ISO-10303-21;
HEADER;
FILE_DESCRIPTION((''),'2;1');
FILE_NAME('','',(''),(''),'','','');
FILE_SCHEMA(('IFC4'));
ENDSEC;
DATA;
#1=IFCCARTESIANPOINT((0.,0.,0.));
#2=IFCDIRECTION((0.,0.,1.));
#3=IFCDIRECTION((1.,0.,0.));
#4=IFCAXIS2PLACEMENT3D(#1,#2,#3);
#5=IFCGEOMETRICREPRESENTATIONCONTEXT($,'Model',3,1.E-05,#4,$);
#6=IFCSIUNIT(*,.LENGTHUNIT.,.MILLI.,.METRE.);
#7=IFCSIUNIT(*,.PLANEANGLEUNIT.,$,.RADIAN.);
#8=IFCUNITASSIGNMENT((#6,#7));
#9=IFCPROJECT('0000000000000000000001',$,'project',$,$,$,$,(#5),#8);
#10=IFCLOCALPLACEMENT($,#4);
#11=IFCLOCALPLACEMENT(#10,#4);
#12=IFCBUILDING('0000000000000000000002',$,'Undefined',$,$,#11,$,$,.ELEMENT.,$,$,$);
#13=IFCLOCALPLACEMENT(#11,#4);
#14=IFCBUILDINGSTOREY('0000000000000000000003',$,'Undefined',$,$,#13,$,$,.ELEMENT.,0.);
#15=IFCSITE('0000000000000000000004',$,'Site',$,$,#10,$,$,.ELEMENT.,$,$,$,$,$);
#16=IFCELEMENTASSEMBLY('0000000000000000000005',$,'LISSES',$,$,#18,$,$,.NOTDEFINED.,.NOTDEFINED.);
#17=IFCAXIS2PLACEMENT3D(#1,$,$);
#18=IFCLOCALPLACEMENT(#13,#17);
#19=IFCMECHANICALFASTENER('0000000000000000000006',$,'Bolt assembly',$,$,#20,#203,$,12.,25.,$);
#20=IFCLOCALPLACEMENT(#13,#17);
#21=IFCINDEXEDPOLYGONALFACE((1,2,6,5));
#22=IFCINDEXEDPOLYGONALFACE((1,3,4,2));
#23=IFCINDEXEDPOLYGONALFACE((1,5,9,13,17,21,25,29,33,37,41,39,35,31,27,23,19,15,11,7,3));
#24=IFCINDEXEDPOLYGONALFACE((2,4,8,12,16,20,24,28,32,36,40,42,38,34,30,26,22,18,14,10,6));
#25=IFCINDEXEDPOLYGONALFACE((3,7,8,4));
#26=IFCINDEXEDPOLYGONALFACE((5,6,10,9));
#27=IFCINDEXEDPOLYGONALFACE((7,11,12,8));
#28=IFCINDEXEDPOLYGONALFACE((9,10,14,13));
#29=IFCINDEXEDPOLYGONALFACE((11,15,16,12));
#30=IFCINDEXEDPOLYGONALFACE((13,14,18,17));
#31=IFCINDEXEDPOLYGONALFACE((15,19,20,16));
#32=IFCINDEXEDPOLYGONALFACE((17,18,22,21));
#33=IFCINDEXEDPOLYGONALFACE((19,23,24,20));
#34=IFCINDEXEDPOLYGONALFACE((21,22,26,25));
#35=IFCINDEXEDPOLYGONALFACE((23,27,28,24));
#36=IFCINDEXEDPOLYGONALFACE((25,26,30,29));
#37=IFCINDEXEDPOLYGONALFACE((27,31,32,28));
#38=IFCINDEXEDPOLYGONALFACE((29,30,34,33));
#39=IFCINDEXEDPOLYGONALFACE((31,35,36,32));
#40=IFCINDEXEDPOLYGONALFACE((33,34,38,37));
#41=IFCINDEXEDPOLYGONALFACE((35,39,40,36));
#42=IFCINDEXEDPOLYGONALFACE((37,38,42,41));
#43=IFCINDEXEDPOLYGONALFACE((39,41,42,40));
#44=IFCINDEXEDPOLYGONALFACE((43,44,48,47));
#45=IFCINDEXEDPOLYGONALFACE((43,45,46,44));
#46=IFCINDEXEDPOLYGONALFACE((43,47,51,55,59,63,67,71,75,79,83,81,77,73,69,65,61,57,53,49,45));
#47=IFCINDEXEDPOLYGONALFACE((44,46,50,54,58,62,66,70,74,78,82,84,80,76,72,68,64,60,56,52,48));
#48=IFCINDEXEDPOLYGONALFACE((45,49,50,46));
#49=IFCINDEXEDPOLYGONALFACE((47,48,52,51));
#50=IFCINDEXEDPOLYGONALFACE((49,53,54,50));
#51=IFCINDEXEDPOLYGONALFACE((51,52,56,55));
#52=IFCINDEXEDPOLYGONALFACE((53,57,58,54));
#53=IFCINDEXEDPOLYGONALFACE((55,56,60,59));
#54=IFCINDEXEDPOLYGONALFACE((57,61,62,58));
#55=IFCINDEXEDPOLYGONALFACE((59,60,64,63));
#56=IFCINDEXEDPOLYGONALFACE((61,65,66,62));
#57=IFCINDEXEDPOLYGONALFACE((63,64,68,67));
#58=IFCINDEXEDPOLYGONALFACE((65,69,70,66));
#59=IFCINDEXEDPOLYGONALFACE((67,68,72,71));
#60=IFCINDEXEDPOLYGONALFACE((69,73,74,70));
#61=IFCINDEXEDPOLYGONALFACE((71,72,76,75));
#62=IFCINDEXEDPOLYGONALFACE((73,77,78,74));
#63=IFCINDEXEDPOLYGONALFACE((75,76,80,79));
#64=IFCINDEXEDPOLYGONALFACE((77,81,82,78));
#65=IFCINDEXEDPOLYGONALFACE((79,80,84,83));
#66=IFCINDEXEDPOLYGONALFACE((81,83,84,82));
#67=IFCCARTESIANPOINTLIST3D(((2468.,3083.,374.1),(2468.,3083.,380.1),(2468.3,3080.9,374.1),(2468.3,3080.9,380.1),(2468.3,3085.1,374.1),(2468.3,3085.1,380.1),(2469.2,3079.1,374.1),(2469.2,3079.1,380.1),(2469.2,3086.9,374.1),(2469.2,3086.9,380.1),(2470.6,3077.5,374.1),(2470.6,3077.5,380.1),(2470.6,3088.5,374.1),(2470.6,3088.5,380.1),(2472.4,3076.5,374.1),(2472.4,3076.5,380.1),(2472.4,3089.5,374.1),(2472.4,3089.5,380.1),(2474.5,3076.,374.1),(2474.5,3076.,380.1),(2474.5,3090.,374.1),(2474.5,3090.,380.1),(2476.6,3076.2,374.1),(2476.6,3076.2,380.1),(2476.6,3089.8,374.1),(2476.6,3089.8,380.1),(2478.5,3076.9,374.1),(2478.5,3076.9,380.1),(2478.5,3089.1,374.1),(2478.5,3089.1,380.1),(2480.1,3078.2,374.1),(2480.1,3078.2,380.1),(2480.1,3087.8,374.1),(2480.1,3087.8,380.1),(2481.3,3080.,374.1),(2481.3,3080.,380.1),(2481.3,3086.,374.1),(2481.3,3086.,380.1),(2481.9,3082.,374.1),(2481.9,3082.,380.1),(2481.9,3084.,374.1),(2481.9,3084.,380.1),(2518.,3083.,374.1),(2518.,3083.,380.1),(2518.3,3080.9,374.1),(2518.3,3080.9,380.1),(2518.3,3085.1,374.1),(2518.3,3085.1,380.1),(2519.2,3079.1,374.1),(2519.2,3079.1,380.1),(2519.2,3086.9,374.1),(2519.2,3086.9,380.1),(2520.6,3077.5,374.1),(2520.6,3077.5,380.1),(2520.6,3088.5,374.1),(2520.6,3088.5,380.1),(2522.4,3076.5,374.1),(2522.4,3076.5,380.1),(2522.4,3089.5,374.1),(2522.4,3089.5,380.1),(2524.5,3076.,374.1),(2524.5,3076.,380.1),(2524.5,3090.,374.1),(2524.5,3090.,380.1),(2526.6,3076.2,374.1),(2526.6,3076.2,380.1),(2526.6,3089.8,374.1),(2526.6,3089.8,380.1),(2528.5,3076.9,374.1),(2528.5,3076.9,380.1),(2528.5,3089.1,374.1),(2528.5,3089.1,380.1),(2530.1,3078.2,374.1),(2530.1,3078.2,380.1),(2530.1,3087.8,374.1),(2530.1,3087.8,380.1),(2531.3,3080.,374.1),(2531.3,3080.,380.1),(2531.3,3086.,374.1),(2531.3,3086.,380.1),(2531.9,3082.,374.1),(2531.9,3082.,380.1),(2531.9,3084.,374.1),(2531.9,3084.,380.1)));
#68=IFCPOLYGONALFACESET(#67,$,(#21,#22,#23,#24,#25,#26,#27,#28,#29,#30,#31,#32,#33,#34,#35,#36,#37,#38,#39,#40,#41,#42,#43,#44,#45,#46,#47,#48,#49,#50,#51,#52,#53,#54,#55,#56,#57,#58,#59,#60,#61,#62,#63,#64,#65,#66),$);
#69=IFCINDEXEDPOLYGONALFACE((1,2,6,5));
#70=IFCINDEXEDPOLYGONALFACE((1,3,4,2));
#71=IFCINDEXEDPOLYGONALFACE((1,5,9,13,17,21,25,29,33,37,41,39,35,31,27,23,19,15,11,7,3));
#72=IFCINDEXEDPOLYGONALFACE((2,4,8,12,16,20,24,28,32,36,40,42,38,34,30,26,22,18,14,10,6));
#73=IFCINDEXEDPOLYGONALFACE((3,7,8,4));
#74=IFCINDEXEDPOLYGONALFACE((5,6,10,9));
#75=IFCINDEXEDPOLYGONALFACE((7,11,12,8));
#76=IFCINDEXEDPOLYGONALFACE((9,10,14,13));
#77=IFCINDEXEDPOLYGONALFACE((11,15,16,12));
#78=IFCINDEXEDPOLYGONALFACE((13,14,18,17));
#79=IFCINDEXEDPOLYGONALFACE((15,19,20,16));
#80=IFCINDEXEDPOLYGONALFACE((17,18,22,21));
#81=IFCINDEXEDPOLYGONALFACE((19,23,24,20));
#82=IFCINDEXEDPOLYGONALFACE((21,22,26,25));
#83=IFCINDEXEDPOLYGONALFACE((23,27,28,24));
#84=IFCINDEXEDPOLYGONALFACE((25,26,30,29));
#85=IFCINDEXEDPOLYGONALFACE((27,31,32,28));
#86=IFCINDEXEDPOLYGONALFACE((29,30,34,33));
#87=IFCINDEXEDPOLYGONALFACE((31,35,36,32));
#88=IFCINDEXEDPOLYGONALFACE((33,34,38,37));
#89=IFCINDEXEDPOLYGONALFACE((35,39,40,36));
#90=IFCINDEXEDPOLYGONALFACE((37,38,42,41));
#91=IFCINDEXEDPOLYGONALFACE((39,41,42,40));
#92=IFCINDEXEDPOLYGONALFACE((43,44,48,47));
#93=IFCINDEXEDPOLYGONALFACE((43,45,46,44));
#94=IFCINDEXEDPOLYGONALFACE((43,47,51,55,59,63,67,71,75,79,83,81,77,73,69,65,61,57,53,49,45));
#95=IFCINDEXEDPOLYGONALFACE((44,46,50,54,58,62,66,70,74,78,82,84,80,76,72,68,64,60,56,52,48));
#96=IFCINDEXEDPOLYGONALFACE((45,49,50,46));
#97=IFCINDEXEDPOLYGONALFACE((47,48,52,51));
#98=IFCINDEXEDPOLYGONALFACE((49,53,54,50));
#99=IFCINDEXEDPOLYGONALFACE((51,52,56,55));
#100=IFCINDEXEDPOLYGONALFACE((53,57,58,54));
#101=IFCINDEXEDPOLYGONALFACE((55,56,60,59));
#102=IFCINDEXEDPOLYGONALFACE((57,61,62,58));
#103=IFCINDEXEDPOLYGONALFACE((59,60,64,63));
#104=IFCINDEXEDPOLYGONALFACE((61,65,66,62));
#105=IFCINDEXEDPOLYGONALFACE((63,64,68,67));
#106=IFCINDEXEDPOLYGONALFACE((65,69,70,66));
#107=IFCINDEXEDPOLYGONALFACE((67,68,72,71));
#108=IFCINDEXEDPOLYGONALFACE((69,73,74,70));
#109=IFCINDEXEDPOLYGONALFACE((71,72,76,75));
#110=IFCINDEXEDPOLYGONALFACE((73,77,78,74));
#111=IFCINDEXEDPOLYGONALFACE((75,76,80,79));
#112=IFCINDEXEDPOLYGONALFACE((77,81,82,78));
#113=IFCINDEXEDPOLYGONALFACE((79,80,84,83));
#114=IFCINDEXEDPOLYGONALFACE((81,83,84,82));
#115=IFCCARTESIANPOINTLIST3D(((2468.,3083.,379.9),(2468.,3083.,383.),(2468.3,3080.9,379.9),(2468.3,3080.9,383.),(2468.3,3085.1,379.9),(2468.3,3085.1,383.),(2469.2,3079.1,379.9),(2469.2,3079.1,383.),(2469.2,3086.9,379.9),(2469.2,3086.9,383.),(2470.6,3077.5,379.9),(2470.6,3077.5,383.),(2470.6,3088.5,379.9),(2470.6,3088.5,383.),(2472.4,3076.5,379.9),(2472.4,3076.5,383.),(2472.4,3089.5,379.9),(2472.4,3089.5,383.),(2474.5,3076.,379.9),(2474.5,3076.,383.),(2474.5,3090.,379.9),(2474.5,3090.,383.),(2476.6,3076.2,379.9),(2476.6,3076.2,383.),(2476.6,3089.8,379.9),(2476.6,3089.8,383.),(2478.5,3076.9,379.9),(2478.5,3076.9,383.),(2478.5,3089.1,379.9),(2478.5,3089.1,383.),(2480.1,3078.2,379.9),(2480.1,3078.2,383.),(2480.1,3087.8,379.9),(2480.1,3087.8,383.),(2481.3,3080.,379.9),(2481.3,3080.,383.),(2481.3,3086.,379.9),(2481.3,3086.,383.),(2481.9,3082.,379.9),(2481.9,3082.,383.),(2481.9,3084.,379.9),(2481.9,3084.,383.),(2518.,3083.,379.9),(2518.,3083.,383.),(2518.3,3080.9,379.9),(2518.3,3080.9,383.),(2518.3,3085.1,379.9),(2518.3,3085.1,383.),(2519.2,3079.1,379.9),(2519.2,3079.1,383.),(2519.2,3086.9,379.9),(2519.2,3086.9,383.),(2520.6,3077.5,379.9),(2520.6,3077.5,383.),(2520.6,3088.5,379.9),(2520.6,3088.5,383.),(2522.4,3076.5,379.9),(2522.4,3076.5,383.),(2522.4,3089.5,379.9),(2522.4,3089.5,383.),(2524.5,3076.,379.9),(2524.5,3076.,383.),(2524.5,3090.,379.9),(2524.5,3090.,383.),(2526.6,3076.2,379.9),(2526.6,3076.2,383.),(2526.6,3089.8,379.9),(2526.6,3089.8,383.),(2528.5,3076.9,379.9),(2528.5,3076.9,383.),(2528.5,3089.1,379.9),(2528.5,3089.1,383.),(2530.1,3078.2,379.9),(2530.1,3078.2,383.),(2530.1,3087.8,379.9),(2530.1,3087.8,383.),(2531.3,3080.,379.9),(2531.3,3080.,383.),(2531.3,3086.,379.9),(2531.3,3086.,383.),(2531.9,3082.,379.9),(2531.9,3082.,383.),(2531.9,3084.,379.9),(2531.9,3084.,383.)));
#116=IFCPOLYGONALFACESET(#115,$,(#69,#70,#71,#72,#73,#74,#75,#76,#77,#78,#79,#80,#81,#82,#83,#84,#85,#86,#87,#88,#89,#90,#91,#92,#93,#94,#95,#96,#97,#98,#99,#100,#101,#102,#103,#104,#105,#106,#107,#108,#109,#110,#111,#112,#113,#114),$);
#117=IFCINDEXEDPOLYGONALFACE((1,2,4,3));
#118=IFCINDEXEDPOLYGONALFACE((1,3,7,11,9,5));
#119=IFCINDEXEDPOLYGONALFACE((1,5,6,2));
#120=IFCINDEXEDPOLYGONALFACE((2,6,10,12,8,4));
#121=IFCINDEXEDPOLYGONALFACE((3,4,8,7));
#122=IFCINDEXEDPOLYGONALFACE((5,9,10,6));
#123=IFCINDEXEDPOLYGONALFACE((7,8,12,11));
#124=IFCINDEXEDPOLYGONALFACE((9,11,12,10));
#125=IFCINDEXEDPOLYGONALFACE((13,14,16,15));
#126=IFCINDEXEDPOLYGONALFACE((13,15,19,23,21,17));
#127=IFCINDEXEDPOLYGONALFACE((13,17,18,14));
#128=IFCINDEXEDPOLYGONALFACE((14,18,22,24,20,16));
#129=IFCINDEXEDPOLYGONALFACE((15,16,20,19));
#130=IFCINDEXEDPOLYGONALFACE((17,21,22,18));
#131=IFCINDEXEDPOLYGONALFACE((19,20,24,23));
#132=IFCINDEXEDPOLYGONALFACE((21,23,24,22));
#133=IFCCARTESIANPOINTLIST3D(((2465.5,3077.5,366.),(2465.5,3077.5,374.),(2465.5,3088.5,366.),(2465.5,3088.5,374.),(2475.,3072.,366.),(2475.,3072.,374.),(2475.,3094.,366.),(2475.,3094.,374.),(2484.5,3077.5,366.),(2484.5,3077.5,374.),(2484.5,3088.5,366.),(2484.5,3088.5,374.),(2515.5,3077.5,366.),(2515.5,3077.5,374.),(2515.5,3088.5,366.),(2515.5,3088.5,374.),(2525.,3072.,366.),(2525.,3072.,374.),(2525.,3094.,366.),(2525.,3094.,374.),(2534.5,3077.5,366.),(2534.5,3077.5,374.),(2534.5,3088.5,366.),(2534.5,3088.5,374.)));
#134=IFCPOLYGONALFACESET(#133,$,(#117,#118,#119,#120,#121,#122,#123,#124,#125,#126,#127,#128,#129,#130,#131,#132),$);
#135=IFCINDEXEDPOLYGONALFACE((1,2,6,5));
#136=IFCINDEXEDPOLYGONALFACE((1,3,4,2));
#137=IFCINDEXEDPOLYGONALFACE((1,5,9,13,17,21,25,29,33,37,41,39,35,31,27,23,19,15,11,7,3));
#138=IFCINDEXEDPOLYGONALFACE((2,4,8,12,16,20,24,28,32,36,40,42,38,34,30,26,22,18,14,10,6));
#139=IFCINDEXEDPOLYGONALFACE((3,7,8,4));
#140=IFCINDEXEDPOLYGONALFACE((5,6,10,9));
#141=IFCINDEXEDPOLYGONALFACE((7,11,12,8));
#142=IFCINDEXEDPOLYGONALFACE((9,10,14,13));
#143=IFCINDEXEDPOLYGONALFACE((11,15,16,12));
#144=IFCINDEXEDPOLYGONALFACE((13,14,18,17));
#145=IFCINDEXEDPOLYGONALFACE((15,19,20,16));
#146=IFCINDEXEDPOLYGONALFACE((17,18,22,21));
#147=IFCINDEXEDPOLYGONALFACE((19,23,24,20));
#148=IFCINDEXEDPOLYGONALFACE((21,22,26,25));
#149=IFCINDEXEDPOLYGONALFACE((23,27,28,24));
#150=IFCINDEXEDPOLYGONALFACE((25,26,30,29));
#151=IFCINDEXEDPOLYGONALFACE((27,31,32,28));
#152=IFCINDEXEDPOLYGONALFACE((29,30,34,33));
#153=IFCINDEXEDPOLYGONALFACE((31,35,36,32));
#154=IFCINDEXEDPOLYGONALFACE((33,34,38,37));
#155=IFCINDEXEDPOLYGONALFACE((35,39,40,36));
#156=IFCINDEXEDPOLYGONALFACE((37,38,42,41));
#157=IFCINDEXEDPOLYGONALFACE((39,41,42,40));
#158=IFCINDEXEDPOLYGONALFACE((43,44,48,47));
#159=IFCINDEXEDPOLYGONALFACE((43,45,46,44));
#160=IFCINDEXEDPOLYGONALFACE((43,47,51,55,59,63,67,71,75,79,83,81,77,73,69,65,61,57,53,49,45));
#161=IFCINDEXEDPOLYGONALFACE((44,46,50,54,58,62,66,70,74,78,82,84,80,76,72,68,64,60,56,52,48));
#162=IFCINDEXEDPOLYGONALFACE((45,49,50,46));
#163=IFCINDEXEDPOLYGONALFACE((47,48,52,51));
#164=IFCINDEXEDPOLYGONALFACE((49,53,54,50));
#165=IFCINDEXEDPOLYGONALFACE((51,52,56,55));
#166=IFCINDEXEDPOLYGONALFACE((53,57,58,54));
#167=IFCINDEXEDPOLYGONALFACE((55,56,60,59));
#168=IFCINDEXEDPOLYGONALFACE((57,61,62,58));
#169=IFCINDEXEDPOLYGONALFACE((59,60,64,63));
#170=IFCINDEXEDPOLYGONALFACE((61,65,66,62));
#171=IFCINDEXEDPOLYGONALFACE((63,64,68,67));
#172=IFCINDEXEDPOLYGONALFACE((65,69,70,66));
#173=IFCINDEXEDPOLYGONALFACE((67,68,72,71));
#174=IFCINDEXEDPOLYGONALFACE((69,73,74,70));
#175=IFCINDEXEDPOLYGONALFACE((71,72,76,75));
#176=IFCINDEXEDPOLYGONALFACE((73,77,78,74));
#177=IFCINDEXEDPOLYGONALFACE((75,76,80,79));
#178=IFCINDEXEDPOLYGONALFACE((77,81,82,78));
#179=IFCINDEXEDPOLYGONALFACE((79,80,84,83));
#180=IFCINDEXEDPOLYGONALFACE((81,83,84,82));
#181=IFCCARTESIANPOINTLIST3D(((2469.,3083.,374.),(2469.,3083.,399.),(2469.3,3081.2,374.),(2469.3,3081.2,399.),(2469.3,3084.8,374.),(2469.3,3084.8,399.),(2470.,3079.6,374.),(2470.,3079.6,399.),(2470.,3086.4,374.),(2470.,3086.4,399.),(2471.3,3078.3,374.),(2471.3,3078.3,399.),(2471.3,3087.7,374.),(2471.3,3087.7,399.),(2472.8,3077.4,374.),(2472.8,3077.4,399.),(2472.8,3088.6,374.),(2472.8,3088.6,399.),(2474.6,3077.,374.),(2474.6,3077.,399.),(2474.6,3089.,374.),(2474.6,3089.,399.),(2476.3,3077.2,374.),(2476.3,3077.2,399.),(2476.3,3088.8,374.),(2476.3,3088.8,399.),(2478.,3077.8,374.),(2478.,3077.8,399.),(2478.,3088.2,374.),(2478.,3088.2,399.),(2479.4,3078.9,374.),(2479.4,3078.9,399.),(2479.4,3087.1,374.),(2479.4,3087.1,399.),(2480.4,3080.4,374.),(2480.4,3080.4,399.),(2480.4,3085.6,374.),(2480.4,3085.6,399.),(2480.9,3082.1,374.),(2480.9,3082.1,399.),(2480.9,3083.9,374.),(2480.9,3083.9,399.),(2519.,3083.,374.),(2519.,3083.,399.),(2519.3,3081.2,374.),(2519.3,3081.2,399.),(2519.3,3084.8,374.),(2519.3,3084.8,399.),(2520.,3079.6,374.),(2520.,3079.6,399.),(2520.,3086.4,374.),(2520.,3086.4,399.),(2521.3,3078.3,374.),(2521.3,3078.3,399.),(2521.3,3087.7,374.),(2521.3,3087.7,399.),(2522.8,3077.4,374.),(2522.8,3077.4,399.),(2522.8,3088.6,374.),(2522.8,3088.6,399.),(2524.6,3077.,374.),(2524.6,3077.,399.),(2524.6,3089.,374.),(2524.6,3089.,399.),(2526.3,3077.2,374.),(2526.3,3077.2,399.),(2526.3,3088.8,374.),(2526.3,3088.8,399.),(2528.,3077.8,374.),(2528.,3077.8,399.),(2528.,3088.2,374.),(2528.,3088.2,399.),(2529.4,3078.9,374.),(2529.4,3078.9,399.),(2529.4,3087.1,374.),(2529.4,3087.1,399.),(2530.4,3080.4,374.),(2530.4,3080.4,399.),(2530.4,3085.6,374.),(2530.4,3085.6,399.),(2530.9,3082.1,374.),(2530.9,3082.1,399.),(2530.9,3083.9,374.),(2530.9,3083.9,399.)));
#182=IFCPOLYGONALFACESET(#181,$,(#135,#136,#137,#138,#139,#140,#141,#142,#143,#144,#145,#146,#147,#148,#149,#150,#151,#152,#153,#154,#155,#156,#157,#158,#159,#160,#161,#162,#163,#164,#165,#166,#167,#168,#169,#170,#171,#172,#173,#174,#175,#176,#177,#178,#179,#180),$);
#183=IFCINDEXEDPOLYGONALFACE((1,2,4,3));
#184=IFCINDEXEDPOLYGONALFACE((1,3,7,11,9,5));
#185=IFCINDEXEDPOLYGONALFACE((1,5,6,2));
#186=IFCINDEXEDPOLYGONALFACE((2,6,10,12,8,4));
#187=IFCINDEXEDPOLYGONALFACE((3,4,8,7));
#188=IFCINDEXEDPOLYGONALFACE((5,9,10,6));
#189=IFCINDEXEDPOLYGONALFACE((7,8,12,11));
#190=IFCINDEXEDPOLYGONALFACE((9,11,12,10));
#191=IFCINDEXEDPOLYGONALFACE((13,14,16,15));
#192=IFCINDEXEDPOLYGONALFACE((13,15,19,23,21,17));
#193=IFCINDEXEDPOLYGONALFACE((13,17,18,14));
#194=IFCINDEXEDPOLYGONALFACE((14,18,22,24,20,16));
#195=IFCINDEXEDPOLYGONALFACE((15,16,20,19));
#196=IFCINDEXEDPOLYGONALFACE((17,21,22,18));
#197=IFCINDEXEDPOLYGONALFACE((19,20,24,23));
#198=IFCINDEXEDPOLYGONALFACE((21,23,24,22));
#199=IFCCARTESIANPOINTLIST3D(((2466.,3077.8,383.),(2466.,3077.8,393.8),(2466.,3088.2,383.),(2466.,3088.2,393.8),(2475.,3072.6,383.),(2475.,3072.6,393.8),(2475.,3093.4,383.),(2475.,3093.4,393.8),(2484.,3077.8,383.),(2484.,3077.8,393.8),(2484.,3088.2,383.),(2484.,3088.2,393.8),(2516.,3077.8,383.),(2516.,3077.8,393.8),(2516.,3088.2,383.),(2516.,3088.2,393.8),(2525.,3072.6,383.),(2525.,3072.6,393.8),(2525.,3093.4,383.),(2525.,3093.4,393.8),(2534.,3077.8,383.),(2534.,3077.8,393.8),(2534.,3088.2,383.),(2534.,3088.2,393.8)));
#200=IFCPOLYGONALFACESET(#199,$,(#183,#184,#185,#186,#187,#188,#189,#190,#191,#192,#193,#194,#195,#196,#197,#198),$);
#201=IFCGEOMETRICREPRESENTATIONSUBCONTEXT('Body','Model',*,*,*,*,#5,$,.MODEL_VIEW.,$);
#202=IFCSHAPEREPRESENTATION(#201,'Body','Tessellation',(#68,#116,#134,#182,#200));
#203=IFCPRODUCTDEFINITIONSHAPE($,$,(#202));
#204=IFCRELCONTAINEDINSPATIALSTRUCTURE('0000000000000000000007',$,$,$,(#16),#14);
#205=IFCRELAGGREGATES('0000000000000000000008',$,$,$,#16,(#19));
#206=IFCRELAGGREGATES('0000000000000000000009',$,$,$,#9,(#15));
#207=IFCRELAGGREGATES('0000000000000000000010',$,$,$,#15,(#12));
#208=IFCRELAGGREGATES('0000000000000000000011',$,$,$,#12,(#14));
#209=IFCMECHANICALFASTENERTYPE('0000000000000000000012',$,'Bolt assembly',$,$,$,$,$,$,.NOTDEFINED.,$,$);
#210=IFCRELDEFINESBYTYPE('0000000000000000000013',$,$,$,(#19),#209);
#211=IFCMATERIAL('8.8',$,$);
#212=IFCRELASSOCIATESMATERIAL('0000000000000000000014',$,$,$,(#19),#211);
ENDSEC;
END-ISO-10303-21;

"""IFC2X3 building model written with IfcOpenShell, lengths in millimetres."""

from ifc_helpers import new_model, si_unit, frame, origin_with_axes, origin_2d_with_axis, place, context, subcontext, project, spatial, polyline, circle, outline, extrude, source, transform, mapped, material, type_object, element, aggregate, save


model = new_model("IFC2X3")

# Units and contexts
model_context = context("Model", 3, precision=1e-05, world=origin_with_axes())
body_context = subcontext(model_context, "Body", "Model", "MODEL_VIEW")
ifc_project = project(units=[si_unit("LENGTHUNIT", "METRE", prefix="MILLI"), si_unit("PLANEANGLEUNIT", "RADIAN")], contexts=[model_context])

# Site, building, storey
site_placement = place(None, origin_with_axes())
site = spatial("IfcSite", under=ifc_project, at=site_placement, Name="Site", CompositionType="ELEMENT")
building_placement = place(site_placement, origin_with_axes())
building = spatial("IfcBuilding", under=site, at=building_placement, Name="Undefined", CompositionType="ELEMENT")
storey_placement = place(building_placement, origin_with_axes())
storey = spatial("IfcBuildingStorey", under=building, at=storey_placement, Name="Undefined", CompositionType="ELEMENT", Elevation=0.0)

# Shared definitions
mechanical_fastener_type = type_object("IfcMechanicalFastenerType", Name="Bolt assembly")
ifc_material_1 = material(Name="8.8")

# Element assembly, mechanical fastener
assembly_1_placement = place(storey_placement, origin_with_axes())
assembly_1 = element("IfcElementAssembly", 1, at=assembly_1_placement, inside=storey, Name="LISSES", AssemblyPlace="NOTDEFINED", PredefinedType="NOTDEFINED")
shared_shape_1 = source(origin_with_axes(), body_context, "Body", "SweptSolid", [
    extrude(circle(Radius=7.0, at=origin_2d_with_axis()), frame((0.0, -5.9, 0.0), z_axis=(0.0, 1.0, 0.0), x_axis=(1.0, 0.0, 0.0)), (0.0, 0.0, 1.0), 6.0),
    extrude(circle(Radius=7.0, at=origin_2d_with_axis()), frame((0.0, -0.1, 0.0), z_axis=(0.0, 1.0, 0.0), x_axis=(1.0, 0.0, 0.0)), (0.0, 0.0, 1.0), 3.1),
    extrude(outline(polyline([(9.5, -5.5), (9.5, 5.5), (0.0, 11.0), (-9.5, 5.5), (-9.5, -5.5), (0.0, -11.0), (9.5, -5.5)])), frame((0.0, -14.0, 0.0), z_axis=(0.0, 1.0, 0.0), x_axis=(1.0, 0.0, 0.0)), (0.0, 0.0, 1.0), 8.0),
    extrude(circle(Radius=6.0, at=origin_2d_with_axis()), frame((0.0, -6.0, 0.0), z_axis=(0.0, 1.0, 0.0), x_axis=(1.0, 0.0, 0.0)), (0.0, 0.0, 1.0), 25.0),
    extrude(outline(polyline([(9.0, -5.2), (9.0, 5.2), (0.0, 10.4), (-9.0, 5.2), (-9.0, -5.2), (0.0, -10.4), (9.0, -5.2)])), frame((0.0, 3.0, 0.0), z_axis=(0.0, 1.0, 0.0), x_axis=(1.0, 0.0, 0.0)), (0.0, 0.0, 1.0), 10.8),
])
mechanical_fastener_1_placement = place(assembly_1_placement, frame((2525.0, 3083.0, 380.0), z_axis=(0.0, 1.0, 0.0), x_axis=(-1.0, 0.0, 0.0)))
mechanical_fastener_1 = element("IfcMechanicalFastener", 2, at=mechanical_fastener_1_placement, type_object=mechanical_fastener_type, material=ifc_material_1, Name="Bolt assembly", NominalDiameter=12.0, NominalLength=25.0, context=body_context, shape_type="MappedRepresentation", body=[
    mapped(shared_shape_1, transform((0.0, 0.0, 0.0))),
    mapped(shared_shape_1, transform((50.0, 0.0, 0.0))),
])
aggregate(assembly_1, [mechanical_fastener_1])

save(model, "model.ifc")
